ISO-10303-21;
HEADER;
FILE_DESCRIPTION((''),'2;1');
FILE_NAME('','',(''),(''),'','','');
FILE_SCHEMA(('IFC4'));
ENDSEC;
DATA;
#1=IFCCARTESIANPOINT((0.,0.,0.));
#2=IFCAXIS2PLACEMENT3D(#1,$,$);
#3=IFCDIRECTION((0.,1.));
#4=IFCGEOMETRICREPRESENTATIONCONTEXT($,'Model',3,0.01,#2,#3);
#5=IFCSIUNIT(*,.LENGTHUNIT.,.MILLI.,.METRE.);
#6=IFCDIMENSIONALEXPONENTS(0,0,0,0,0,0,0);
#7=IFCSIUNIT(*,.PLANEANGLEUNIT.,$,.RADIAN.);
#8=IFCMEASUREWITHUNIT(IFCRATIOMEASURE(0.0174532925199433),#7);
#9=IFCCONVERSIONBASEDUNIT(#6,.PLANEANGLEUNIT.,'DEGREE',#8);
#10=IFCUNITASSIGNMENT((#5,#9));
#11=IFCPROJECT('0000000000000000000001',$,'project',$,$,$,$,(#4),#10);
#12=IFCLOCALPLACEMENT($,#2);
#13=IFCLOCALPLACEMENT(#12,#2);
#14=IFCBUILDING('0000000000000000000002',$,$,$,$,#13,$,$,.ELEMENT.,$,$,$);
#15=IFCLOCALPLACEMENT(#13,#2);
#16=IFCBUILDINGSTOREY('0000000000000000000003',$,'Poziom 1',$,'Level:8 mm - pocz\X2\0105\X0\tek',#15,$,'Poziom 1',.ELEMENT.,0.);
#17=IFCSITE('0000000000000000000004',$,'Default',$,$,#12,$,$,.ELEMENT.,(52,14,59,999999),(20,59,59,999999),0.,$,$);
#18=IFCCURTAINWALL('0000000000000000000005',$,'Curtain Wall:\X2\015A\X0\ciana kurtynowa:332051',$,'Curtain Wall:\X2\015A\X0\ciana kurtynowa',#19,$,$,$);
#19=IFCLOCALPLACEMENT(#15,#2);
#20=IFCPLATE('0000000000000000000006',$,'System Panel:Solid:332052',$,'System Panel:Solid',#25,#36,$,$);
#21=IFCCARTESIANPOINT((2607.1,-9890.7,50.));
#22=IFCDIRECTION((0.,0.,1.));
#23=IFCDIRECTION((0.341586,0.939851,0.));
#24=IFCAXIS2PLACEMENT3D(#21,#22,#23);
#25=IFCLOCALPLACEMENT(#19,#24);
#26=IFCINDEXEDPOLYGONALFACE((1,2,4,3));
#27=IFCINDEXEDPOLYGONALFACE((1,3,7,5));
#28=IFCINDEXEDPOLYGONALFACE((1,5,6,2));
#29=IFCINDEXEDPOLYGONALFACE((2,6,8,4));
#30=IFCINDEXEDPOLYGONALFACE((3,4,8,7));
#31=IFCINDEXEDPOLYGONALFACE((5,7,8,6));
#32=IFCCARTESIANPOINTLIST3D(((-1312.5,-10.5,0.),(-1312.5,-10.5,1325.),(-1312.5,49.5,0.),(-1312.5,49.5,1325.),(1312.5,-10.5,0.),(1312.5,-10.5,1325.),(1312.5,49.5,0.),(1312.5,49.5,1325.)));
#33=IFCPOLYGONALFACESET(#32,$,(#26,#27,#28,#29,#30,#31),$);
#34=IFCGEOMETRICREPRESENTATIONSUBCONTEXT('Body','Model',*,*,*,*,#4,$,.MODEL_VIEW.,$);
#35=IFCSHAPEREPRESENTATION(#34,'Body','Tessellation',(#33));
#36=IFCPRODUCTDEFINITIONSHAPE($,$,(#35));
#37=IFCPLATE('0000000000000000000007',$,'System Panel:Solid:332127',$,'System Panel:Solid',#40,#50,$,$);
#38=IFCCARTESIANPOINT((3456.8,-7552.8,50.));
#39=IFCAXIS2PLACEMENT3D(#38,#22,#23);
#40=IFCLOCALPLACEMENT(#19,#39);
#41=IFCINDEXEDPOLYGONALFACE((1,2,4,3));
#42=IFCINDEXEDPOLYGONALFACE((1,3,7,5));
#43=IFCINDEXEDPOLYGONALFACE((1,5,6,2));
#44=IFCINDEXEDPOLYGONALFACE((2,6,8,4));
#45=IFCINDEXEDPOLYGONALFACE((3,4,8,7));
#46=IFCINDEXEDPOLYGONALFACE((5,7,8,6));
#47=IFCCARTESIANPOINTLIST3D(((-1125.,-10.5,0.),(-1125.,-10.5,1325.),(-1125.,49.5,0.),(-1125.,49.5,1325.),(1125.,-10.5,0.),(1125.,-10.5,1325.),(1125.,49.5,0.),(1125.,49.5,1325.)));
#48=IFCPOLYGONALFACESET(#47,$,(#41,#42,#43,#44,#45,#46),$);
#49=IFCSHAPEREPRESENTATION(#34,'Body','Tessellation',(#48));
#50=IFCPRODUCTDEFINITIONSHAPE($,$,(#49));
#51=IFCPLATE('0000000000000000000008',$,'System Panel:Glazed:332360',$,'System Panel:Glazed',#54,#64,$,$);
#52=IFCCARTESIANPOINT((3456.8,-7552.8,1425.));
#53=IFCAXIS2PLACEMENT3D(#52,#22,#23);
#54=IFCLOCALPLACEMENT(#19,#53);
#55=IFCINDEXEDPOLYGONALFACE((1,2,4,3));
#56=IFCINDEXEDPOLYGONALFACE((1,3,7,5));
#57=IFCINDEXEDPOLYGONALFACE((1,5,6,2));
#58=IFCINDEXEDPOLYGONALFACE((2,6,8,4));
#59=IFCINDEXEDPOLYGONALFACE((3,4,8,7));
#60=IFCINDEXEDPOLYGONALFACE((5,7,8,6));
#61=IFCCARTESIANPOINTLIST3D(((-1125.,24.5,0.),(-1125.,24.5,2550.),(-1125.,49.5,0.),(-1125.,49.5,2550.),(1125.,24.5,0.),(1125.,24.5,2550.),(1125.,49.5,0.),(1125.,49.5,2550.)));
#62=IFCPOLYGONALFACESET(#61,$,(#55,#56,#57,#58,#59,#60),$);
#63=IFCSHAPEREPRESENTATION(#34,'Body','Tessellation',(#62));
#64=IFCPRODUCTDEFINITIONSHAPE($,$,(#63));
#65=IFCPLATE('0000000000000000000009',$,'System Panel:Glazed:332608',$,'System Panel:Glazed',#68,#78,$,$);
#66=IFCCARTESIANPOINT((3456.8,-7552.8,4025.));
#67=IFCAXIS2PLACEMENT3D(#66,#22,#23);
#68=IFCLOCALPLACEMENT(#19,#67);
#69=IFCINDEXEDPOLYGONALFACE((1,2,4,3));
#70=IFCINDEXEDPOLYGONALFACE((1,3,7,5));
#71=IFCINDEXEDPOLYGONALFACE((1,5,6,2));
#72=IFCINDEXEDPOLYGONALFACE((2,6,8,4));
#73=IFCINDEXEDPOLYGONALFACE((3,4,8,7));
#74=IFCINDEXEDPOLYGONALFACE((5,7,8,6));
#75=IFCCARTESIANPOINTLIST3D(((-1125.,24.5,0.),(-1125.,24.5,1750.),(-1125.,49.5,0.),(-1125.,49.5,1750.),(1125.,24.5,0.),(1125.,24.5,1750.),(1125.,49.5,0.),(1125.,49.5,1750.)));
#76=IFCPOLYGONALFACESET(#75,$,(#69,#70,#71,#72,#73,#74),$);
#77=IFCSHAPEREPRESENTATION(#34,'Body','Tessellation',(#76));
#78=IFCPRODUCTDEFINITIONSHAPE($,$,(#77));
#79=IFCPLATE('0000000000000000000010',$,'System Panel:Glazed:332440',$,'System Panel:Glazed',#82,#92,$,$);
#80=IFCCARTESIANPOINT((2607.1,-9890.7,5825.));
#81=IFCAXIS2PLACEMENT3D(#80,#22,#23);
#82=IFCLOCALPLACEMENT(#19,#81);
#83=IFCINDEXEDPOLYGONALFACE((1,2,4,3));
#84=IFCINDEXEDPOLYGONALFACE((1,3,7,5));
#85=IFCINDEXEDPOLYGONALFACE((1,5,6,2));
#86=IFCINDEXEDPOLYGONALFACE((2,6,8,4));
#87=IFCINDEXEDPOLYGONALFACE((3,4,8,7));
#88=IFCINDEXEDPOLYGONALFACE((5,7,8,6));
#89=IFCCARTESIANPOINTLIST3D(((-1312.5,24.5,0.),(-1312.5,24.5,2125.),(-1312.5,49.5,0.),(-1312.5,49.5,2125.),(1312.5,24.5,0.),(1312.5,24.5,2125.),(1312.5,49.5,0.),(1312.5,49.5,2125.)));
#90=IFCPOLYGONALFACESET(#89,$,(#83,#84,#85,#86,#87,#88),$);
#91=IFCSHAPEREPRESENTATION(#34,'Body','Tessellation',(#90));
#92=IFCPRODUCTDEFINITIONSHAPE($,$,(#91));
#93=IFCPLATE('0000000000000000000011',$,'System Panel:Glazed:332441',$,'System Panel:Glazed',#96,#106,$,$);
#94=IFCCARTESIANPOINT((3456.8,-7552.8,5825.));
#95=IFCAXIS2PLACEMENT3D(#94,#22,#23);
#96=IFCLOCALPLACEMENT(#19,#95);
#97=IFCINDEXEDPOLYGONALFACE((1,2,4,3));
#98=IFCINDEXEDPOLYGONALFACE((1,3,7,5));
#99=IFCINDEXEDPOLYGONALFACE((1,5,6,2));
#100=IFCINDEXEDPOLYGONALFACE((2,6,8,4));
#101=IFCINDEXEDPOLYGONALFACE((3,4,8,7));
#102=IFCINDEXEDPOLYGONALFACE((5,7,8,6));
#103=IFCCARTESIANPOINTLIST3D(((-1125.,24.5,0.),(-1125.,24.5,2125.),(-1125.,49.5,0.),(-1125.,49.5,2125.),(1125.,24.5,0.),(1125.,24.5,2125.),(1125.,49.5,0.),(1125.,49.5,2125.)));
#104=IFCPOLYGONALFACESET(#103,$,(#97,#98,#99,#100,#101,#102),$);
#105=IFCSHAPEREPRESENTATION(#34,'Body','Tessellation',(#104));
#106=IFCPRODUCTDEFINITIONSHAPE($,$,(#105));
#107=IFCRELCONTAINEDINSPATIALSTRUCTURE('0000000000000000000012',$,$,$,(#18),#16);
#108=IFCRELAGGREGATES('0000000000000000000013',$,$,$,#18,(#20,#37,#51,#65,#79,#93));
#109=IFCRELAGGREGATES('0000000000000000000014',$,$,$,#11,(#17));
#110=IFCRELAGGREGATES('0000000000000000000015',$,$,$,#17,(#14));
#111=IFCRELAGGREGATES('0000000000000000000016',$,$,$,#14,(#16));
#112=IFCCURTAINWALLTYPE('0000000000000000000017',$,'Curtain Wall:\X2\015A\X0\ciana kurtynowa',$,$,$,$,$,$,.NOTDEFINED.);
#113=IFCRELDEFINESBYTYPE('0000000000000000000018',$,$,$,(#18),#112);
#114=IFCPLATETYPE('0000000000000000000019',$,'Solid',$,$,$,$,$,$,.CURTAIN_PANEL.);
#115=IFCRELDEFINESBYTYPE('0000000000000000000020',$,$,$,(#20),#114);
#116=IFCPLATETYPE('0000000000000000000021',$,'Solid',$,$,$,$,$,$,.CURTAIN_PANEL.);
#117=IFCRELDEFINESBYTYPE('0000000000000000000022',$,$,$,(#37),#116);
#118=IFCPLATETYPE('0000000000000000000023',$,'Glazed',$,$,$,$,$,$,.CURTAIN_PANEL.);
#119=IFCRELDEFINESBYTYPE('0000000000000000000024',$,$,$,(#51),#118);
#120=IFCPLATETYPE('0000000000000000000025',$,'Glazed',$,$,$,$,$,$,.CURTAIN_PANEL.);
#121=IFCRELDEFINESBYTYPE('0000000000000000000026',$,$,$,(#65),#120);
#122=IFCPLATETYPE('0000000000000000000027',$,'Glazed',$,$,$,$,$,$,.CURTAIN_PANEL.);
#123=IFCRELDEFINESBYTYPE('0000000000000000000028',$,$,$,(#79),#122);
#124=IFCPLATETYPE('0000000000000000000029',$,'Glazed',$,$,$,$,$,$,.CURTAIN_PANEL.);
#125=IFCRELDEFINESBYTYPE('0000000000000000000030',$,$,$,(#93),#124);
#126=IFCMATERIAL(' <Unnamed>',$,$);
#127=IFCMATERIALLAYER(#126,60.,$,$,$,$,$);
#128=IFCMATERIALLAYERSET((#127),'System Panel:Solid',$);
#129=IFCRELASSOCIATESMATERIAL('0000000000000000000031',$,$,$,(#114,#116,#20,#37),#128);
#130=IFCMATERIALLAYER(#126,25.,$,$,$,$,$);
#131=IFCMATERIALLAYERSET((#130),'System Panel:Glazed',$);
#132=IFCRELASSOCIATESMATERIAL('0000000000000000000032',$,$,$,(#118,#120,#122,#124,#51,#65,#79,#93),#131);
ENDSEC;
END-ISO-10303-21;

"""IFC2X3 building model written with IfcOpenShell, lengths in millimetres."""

from ifc_helpers import new_model, entity, si_unit, converted_unit, direction, frame, frame_2d, origin, origin_2d_with_axis, place, context, subcontext, project, spatial, rectangle, extrude, source, transform, mapped, material, layer, layer_set, layer_usage, type_object, type_shapes, element, aggregate, save


model = new_model("IFC2X3")

# Units and contexts
model_context = context("Model", 3, precision=0.01, world=origin(), true_north=direction((0.0, 1.0)))
body_context = subcontext(model_context, "Body", "Model", "MODEL_VIEW")
ifc_project = project(units=[si_unit("LENGTHUNIT", "METRE", prefix="MILLI"), converted_unit("PLANEANGLEUNIT", "DEGREE", entity("IfcRatioMeasure", 0.0174532925199433), si_unit("PLANEANGLEUNIT", "RADIAN"), dimensions=[0, 0, 0, 0, 0, 0, 0])], contexts=[model_context])

# Site, building, storey
site_placement = place(None, origin())
site = spatial("IfcSite", under=ifc_project, at=site_placement, Name="Default", CompositionType="ELEMENT", RefLatitude=(52, 14, 59, 999999), RefLongitude=(20, 59, 59, 999999), RefElevation=0.0)
building_placement = place(site_placement, origin())
building = spatial("IfcBuilding", under=site, at=building_placement, CompositionType="ELEMENT")
storey_placement = place(building_placement, origin())
storey = spatial("IfcBuildingStorey", under=building, at=storey_placement, Name="Poziom 1", ObjectType="Level:8 mm - początek", LongName="Poziom 1", CompositionType="ELEMENT", Elevation=0.0)

# Curtain wall, plates
curtain_wall_type = type_object("IfcCurtainWallType", Name="Curtain Wall:Ściana kurtynowa", PredefinedType="NOTDEFINED")
curtain_wall_placement = place(storey_placement, origin())
curtain_wall = element("IfcCurtainWall", 1, at=curtain_wall_placement, inside=storey, type_object=curtain_wall_type, Name="Curtain Wall:Ściana kurtynowa:332051", ObjectType="Curtain Wall:Ściana kurtynowa")
ifc_material_1 = material(Name=" <Unnamed>")
ifc_layer_1 = layer(ifc_material_1, 60.0)
ifc_layer_set_1 = layer_set([ifc_layer_1], Name="System Panel:Solid")
ifc_layer_usage_1 = layer_usage(ifc_layer_set_1, "AXIS3", "POSITIVE", 0.1)
plate_type_1 = type_object("IfcPlateType", Name="Solid", PredefinedType="CURTAIN_PANEL", material=ifc_layer_set_1)
shared_shape_1 = source(origin(), body_context, "Body", "SweptSolid", [
    extrude(rectangle(XDim=60.0, YDim=2625.0, at=frame_2d((0.0, 0.0), x_axis=(1.0, 0.0))), frame((0.0, 19.5, 0.0), z_axis=(0.0, 0.0, 1.0), x_axis=(0.0, 1.0, 0.0)), (0.0, 0.0, 1.0), 1325.0),
])
type_shapes(plate_type_1, [shared_shape_1])
plate_1_placement = place(curtain_wall_placement, frame((2607.1, -9890.7, 50.0), z_axis=(0.0, 0.0, 1.0), x_axis=(0.341586, 0.939851, 0.0)))
plate_1 = element("IfcPlate", 2, at=plate_1_placement, type_object=plate_type_1, material=ifc_layer_usage_1, Name="System Panel:Solid:332052", ObjectType="System Panel:Solid", context=body_context, shape_type="MappedRepresentation", body=[
    mapped(shared_shape_1, transform((0.0, 0.0, 0.0), scale=1.0)),
])
ifc_layer_usage_2 = layer_usage(ifc_layer_set_1, "AXIS3", "POSITIVE", 0.1)
plate_type_2 = type_object("IfcPlateType", Name="Solid", PredefinedType="CURTAIN_PANEL", material=ifc_layer_set_1)
shared_shape_2 = source(origin(), body_context, "Body", "SweptSolid", [
    extrude(rectangle(XDim=60.0, YDim=2250.0, at=origin_2d_with_axis()), frame((0.0, 19.5, 0.0), z_axis=(0.0, 0.0, 1.0), x_axis=(0.0, 1.0, 0.0)), (0.0, 0.0, 1.0), 1325.0),
])
type_shapes(plate_type_2, [shared_shape_2])
plate_2_placement = place(curtain_wall_placement, frame((3456.8, -7552.8, 50.0), z_axis=(0.0, 0.0, 1.0), x_axis=(0.341586, 0.939851, 0.0)))
plate_2 = element("IfcPlate", 3, at=plate_2_placement, type_object=plate_type_2, material=ifc_layer_usage_2, Name="System Panel:Solid:332127", ObjectType="System Panel:Solid", context=body_context, shape_type="MappedRepresentation", body=[
    mapped(shared_shape_2, transform((0.0, 0.0, 0.0), scale=1.0)),
])
ifc_layer_2 = layer(ifc_material_1, 25.0)
ifc_layer_set_2 = layer_set([ifc_layer_2], Name="System Panel:Glazed")
ifc_layer_usage_3 = layer_usage(ifc_layer_set_2, "AXIS3", "POSITIVE", 0.1)
plate_type_3 = type_object("IfcPlateType", Name="Glazed", PredefinedType="CURTAIN_PANEL", material=ifc_layer_set_2)
shared_shape_3 = source(origin(), body_context, "Body", "SweptSolid", [
    extrude(rectangle(XDim=25.0, YDim=2250.0, at=frame_2d((0.0, 0.0), x_axis=(1.0, 0.0))), frame((0.0, 37.0, 0.0), z_axis=(0.0, 0.0, 1.0), x_axis=(0.0, 1.0, 0.0)), (0.0, 0.0, 1.0), 2550.0),
])
type_shapes(plate_type_3, [shared_shape_3])
plate_3_placement = place(curtain_wall_placement, frame((3456.8, -7552.8, 1425.0), z_axis=(0.0, 0.0, 1.0), x_axis=(0.341586, 0.939851, 0.0)))
plate_3 = element("IfcPlate", 4, at=plate_3_placement, type_object=plate_type_3, material=ifc_layer_usage_3, Name="System Panel:Glazed:332360", ObjectType="System Panel:Glazed", context=body_context, shape_type="MappedRepresentation", body=[
    mapped(shared_shape_3, transform((0.0, 0.0, 0.0), scale=1.0)),
])
ifc_layer_usage_4 = layer_usage(ifc_layer_set_2, "AXIS3", "POSITIVE", 0.1)
plate_type_4 = type_object("IfcPlateType", Name="Glazed", PredefinedType="CURTAIN_PANEL", material=ifc_layer_set_2)
shared_shape_4 = source(origin(), body_context, "Body", "SweptSolid", [
    extrude(rectangle(XDim=25.0, YDim=2250.0, at=frame_2d((0.0, 0.0), x_axis=(1.0, 0.0))), frame((0.0, 37.0, 0.0), z_axis=(0.0, 0.0, 1.0), x_axis=(0.0, 1.0, 0.0)), (0.0, 0.0, 1.0), 1750.0),
])
type_shapes(plate_type_4, [shared_shape_4])
plate_4_placement = place(curtain_wall_placement, frame((3456.8, -7552.8, 4025.0), z_axis=(0.0, 0.0, 1.0), x_axis=(0.341586, 0.939851, 0.0)))
plate_4 = element("IfcPlate", 5, at=plate_4_placement, type_object=plate_type_4, material=ifc_layer_usage_4, Name="System Panel:Glazed:332608", ObjectType="System Panel:Glazed", context=body_context, shape_type="MappedRepresentation", body=[
    mapped(shared_shape_4, transform((0.0, 0.0, 0.0), scale=1.0)),
])
ifc_layer_usage_5 = layer_usage(ifc_layer_set_2, "AXIS3", "POSITIVE", 0.1)
plate_type_5 = type_object("IfcPlateType", Name="Glazed", PredefinedType="CURTAIN_PANEL", material=ifc_layer_set_2)
shared_shape_5 = source(origin(), body_context, "Body", "SweptSolid", [
    extrude(rectangle(XDim=25.0, YDim=2625.0, at=frame_2d((0.0, 0.0), x_axis=(1.0, 0.0))), frame((0.0, 37.0, 0.0), z_axis=(0.0, 0.0, 1.0), x_axis=(0.0, 1.0, 0.0)), (0.0, 0.0, 1.0), 2125.0),
])
type_shapes(plate_type_5, [shared_shape_5])
plate_5_placement = place(curtain_wall_placement, frame((2607.1, -9890.7, 5825.0), z_axis=(0.0, 0.0, 1.0), x_axis=(0.341586, 0.939851, 0.0)))
plate_5 = element("IfcPlate", 6, at=plate_5_placement, type_object=plate_type_5, material=ifc_layer_usage_5, Name="System Panel:Glazed:332440", ObjectType="System Panel:Glazed", context=body_context, shape_type="MappedRepresentation", body=[
    mapped(shared_shape_5, transform((0.0, 0.0, 0.0), scale=1.0)),
])
ifc_layer_usage_6 = layer_usage(ifc_layer_set_2, "AXIS3", "POSITIVE", 0.1)
plate_type_6 = type_object("IfcPlateType", Name="Glazed", PredefinedType="CURTAIN_PANEL", material=ifc_layer_set_2)
shared_shape_6 = source(origin(), body_context, "Body", "SweptSolid", [
    extrude(rectangle(XDim=25.0, YDim=2250.0, at=frame_2d((0.0, 0.0), x_axis=(1.0, 0.0))), frame((0.0, 37.0, 0.0), z_axis=(0.0, 0.0, 1.0), x_axis=(0.0, 1.0, 0.0)), (0.0, 0.0, 1.0), 2125.0),
])
type_shapes(plate_type_6, [shared_shape_6])
plate_6_placement = place(curtain_wall_placement, frame((3456.8, -7552.8, 5825.0), z_axis=(0.0, 0.0, 1.0), x_axis=(0.341586, 0.939851, 0.0)))
plate_6 = element("IfcPlate", 7, at=plate_6_placement, type_object=plate_type_6, material=ifc_layer_usage_6, Name="System Panel:Glazed:332441", ObjectType="System Panel:Glazed", context=body_context, shape_type="MappedRepresentation", body=[
    mapped(shared_shape_6, transform((0.0, 0.0, 0.0), scale=1.0)),
])
aggregate(curtain_wall, [plate_1, plate_2, plate_3, plate_4, plate_5, plate_6])

save(model, "model.ifc")
